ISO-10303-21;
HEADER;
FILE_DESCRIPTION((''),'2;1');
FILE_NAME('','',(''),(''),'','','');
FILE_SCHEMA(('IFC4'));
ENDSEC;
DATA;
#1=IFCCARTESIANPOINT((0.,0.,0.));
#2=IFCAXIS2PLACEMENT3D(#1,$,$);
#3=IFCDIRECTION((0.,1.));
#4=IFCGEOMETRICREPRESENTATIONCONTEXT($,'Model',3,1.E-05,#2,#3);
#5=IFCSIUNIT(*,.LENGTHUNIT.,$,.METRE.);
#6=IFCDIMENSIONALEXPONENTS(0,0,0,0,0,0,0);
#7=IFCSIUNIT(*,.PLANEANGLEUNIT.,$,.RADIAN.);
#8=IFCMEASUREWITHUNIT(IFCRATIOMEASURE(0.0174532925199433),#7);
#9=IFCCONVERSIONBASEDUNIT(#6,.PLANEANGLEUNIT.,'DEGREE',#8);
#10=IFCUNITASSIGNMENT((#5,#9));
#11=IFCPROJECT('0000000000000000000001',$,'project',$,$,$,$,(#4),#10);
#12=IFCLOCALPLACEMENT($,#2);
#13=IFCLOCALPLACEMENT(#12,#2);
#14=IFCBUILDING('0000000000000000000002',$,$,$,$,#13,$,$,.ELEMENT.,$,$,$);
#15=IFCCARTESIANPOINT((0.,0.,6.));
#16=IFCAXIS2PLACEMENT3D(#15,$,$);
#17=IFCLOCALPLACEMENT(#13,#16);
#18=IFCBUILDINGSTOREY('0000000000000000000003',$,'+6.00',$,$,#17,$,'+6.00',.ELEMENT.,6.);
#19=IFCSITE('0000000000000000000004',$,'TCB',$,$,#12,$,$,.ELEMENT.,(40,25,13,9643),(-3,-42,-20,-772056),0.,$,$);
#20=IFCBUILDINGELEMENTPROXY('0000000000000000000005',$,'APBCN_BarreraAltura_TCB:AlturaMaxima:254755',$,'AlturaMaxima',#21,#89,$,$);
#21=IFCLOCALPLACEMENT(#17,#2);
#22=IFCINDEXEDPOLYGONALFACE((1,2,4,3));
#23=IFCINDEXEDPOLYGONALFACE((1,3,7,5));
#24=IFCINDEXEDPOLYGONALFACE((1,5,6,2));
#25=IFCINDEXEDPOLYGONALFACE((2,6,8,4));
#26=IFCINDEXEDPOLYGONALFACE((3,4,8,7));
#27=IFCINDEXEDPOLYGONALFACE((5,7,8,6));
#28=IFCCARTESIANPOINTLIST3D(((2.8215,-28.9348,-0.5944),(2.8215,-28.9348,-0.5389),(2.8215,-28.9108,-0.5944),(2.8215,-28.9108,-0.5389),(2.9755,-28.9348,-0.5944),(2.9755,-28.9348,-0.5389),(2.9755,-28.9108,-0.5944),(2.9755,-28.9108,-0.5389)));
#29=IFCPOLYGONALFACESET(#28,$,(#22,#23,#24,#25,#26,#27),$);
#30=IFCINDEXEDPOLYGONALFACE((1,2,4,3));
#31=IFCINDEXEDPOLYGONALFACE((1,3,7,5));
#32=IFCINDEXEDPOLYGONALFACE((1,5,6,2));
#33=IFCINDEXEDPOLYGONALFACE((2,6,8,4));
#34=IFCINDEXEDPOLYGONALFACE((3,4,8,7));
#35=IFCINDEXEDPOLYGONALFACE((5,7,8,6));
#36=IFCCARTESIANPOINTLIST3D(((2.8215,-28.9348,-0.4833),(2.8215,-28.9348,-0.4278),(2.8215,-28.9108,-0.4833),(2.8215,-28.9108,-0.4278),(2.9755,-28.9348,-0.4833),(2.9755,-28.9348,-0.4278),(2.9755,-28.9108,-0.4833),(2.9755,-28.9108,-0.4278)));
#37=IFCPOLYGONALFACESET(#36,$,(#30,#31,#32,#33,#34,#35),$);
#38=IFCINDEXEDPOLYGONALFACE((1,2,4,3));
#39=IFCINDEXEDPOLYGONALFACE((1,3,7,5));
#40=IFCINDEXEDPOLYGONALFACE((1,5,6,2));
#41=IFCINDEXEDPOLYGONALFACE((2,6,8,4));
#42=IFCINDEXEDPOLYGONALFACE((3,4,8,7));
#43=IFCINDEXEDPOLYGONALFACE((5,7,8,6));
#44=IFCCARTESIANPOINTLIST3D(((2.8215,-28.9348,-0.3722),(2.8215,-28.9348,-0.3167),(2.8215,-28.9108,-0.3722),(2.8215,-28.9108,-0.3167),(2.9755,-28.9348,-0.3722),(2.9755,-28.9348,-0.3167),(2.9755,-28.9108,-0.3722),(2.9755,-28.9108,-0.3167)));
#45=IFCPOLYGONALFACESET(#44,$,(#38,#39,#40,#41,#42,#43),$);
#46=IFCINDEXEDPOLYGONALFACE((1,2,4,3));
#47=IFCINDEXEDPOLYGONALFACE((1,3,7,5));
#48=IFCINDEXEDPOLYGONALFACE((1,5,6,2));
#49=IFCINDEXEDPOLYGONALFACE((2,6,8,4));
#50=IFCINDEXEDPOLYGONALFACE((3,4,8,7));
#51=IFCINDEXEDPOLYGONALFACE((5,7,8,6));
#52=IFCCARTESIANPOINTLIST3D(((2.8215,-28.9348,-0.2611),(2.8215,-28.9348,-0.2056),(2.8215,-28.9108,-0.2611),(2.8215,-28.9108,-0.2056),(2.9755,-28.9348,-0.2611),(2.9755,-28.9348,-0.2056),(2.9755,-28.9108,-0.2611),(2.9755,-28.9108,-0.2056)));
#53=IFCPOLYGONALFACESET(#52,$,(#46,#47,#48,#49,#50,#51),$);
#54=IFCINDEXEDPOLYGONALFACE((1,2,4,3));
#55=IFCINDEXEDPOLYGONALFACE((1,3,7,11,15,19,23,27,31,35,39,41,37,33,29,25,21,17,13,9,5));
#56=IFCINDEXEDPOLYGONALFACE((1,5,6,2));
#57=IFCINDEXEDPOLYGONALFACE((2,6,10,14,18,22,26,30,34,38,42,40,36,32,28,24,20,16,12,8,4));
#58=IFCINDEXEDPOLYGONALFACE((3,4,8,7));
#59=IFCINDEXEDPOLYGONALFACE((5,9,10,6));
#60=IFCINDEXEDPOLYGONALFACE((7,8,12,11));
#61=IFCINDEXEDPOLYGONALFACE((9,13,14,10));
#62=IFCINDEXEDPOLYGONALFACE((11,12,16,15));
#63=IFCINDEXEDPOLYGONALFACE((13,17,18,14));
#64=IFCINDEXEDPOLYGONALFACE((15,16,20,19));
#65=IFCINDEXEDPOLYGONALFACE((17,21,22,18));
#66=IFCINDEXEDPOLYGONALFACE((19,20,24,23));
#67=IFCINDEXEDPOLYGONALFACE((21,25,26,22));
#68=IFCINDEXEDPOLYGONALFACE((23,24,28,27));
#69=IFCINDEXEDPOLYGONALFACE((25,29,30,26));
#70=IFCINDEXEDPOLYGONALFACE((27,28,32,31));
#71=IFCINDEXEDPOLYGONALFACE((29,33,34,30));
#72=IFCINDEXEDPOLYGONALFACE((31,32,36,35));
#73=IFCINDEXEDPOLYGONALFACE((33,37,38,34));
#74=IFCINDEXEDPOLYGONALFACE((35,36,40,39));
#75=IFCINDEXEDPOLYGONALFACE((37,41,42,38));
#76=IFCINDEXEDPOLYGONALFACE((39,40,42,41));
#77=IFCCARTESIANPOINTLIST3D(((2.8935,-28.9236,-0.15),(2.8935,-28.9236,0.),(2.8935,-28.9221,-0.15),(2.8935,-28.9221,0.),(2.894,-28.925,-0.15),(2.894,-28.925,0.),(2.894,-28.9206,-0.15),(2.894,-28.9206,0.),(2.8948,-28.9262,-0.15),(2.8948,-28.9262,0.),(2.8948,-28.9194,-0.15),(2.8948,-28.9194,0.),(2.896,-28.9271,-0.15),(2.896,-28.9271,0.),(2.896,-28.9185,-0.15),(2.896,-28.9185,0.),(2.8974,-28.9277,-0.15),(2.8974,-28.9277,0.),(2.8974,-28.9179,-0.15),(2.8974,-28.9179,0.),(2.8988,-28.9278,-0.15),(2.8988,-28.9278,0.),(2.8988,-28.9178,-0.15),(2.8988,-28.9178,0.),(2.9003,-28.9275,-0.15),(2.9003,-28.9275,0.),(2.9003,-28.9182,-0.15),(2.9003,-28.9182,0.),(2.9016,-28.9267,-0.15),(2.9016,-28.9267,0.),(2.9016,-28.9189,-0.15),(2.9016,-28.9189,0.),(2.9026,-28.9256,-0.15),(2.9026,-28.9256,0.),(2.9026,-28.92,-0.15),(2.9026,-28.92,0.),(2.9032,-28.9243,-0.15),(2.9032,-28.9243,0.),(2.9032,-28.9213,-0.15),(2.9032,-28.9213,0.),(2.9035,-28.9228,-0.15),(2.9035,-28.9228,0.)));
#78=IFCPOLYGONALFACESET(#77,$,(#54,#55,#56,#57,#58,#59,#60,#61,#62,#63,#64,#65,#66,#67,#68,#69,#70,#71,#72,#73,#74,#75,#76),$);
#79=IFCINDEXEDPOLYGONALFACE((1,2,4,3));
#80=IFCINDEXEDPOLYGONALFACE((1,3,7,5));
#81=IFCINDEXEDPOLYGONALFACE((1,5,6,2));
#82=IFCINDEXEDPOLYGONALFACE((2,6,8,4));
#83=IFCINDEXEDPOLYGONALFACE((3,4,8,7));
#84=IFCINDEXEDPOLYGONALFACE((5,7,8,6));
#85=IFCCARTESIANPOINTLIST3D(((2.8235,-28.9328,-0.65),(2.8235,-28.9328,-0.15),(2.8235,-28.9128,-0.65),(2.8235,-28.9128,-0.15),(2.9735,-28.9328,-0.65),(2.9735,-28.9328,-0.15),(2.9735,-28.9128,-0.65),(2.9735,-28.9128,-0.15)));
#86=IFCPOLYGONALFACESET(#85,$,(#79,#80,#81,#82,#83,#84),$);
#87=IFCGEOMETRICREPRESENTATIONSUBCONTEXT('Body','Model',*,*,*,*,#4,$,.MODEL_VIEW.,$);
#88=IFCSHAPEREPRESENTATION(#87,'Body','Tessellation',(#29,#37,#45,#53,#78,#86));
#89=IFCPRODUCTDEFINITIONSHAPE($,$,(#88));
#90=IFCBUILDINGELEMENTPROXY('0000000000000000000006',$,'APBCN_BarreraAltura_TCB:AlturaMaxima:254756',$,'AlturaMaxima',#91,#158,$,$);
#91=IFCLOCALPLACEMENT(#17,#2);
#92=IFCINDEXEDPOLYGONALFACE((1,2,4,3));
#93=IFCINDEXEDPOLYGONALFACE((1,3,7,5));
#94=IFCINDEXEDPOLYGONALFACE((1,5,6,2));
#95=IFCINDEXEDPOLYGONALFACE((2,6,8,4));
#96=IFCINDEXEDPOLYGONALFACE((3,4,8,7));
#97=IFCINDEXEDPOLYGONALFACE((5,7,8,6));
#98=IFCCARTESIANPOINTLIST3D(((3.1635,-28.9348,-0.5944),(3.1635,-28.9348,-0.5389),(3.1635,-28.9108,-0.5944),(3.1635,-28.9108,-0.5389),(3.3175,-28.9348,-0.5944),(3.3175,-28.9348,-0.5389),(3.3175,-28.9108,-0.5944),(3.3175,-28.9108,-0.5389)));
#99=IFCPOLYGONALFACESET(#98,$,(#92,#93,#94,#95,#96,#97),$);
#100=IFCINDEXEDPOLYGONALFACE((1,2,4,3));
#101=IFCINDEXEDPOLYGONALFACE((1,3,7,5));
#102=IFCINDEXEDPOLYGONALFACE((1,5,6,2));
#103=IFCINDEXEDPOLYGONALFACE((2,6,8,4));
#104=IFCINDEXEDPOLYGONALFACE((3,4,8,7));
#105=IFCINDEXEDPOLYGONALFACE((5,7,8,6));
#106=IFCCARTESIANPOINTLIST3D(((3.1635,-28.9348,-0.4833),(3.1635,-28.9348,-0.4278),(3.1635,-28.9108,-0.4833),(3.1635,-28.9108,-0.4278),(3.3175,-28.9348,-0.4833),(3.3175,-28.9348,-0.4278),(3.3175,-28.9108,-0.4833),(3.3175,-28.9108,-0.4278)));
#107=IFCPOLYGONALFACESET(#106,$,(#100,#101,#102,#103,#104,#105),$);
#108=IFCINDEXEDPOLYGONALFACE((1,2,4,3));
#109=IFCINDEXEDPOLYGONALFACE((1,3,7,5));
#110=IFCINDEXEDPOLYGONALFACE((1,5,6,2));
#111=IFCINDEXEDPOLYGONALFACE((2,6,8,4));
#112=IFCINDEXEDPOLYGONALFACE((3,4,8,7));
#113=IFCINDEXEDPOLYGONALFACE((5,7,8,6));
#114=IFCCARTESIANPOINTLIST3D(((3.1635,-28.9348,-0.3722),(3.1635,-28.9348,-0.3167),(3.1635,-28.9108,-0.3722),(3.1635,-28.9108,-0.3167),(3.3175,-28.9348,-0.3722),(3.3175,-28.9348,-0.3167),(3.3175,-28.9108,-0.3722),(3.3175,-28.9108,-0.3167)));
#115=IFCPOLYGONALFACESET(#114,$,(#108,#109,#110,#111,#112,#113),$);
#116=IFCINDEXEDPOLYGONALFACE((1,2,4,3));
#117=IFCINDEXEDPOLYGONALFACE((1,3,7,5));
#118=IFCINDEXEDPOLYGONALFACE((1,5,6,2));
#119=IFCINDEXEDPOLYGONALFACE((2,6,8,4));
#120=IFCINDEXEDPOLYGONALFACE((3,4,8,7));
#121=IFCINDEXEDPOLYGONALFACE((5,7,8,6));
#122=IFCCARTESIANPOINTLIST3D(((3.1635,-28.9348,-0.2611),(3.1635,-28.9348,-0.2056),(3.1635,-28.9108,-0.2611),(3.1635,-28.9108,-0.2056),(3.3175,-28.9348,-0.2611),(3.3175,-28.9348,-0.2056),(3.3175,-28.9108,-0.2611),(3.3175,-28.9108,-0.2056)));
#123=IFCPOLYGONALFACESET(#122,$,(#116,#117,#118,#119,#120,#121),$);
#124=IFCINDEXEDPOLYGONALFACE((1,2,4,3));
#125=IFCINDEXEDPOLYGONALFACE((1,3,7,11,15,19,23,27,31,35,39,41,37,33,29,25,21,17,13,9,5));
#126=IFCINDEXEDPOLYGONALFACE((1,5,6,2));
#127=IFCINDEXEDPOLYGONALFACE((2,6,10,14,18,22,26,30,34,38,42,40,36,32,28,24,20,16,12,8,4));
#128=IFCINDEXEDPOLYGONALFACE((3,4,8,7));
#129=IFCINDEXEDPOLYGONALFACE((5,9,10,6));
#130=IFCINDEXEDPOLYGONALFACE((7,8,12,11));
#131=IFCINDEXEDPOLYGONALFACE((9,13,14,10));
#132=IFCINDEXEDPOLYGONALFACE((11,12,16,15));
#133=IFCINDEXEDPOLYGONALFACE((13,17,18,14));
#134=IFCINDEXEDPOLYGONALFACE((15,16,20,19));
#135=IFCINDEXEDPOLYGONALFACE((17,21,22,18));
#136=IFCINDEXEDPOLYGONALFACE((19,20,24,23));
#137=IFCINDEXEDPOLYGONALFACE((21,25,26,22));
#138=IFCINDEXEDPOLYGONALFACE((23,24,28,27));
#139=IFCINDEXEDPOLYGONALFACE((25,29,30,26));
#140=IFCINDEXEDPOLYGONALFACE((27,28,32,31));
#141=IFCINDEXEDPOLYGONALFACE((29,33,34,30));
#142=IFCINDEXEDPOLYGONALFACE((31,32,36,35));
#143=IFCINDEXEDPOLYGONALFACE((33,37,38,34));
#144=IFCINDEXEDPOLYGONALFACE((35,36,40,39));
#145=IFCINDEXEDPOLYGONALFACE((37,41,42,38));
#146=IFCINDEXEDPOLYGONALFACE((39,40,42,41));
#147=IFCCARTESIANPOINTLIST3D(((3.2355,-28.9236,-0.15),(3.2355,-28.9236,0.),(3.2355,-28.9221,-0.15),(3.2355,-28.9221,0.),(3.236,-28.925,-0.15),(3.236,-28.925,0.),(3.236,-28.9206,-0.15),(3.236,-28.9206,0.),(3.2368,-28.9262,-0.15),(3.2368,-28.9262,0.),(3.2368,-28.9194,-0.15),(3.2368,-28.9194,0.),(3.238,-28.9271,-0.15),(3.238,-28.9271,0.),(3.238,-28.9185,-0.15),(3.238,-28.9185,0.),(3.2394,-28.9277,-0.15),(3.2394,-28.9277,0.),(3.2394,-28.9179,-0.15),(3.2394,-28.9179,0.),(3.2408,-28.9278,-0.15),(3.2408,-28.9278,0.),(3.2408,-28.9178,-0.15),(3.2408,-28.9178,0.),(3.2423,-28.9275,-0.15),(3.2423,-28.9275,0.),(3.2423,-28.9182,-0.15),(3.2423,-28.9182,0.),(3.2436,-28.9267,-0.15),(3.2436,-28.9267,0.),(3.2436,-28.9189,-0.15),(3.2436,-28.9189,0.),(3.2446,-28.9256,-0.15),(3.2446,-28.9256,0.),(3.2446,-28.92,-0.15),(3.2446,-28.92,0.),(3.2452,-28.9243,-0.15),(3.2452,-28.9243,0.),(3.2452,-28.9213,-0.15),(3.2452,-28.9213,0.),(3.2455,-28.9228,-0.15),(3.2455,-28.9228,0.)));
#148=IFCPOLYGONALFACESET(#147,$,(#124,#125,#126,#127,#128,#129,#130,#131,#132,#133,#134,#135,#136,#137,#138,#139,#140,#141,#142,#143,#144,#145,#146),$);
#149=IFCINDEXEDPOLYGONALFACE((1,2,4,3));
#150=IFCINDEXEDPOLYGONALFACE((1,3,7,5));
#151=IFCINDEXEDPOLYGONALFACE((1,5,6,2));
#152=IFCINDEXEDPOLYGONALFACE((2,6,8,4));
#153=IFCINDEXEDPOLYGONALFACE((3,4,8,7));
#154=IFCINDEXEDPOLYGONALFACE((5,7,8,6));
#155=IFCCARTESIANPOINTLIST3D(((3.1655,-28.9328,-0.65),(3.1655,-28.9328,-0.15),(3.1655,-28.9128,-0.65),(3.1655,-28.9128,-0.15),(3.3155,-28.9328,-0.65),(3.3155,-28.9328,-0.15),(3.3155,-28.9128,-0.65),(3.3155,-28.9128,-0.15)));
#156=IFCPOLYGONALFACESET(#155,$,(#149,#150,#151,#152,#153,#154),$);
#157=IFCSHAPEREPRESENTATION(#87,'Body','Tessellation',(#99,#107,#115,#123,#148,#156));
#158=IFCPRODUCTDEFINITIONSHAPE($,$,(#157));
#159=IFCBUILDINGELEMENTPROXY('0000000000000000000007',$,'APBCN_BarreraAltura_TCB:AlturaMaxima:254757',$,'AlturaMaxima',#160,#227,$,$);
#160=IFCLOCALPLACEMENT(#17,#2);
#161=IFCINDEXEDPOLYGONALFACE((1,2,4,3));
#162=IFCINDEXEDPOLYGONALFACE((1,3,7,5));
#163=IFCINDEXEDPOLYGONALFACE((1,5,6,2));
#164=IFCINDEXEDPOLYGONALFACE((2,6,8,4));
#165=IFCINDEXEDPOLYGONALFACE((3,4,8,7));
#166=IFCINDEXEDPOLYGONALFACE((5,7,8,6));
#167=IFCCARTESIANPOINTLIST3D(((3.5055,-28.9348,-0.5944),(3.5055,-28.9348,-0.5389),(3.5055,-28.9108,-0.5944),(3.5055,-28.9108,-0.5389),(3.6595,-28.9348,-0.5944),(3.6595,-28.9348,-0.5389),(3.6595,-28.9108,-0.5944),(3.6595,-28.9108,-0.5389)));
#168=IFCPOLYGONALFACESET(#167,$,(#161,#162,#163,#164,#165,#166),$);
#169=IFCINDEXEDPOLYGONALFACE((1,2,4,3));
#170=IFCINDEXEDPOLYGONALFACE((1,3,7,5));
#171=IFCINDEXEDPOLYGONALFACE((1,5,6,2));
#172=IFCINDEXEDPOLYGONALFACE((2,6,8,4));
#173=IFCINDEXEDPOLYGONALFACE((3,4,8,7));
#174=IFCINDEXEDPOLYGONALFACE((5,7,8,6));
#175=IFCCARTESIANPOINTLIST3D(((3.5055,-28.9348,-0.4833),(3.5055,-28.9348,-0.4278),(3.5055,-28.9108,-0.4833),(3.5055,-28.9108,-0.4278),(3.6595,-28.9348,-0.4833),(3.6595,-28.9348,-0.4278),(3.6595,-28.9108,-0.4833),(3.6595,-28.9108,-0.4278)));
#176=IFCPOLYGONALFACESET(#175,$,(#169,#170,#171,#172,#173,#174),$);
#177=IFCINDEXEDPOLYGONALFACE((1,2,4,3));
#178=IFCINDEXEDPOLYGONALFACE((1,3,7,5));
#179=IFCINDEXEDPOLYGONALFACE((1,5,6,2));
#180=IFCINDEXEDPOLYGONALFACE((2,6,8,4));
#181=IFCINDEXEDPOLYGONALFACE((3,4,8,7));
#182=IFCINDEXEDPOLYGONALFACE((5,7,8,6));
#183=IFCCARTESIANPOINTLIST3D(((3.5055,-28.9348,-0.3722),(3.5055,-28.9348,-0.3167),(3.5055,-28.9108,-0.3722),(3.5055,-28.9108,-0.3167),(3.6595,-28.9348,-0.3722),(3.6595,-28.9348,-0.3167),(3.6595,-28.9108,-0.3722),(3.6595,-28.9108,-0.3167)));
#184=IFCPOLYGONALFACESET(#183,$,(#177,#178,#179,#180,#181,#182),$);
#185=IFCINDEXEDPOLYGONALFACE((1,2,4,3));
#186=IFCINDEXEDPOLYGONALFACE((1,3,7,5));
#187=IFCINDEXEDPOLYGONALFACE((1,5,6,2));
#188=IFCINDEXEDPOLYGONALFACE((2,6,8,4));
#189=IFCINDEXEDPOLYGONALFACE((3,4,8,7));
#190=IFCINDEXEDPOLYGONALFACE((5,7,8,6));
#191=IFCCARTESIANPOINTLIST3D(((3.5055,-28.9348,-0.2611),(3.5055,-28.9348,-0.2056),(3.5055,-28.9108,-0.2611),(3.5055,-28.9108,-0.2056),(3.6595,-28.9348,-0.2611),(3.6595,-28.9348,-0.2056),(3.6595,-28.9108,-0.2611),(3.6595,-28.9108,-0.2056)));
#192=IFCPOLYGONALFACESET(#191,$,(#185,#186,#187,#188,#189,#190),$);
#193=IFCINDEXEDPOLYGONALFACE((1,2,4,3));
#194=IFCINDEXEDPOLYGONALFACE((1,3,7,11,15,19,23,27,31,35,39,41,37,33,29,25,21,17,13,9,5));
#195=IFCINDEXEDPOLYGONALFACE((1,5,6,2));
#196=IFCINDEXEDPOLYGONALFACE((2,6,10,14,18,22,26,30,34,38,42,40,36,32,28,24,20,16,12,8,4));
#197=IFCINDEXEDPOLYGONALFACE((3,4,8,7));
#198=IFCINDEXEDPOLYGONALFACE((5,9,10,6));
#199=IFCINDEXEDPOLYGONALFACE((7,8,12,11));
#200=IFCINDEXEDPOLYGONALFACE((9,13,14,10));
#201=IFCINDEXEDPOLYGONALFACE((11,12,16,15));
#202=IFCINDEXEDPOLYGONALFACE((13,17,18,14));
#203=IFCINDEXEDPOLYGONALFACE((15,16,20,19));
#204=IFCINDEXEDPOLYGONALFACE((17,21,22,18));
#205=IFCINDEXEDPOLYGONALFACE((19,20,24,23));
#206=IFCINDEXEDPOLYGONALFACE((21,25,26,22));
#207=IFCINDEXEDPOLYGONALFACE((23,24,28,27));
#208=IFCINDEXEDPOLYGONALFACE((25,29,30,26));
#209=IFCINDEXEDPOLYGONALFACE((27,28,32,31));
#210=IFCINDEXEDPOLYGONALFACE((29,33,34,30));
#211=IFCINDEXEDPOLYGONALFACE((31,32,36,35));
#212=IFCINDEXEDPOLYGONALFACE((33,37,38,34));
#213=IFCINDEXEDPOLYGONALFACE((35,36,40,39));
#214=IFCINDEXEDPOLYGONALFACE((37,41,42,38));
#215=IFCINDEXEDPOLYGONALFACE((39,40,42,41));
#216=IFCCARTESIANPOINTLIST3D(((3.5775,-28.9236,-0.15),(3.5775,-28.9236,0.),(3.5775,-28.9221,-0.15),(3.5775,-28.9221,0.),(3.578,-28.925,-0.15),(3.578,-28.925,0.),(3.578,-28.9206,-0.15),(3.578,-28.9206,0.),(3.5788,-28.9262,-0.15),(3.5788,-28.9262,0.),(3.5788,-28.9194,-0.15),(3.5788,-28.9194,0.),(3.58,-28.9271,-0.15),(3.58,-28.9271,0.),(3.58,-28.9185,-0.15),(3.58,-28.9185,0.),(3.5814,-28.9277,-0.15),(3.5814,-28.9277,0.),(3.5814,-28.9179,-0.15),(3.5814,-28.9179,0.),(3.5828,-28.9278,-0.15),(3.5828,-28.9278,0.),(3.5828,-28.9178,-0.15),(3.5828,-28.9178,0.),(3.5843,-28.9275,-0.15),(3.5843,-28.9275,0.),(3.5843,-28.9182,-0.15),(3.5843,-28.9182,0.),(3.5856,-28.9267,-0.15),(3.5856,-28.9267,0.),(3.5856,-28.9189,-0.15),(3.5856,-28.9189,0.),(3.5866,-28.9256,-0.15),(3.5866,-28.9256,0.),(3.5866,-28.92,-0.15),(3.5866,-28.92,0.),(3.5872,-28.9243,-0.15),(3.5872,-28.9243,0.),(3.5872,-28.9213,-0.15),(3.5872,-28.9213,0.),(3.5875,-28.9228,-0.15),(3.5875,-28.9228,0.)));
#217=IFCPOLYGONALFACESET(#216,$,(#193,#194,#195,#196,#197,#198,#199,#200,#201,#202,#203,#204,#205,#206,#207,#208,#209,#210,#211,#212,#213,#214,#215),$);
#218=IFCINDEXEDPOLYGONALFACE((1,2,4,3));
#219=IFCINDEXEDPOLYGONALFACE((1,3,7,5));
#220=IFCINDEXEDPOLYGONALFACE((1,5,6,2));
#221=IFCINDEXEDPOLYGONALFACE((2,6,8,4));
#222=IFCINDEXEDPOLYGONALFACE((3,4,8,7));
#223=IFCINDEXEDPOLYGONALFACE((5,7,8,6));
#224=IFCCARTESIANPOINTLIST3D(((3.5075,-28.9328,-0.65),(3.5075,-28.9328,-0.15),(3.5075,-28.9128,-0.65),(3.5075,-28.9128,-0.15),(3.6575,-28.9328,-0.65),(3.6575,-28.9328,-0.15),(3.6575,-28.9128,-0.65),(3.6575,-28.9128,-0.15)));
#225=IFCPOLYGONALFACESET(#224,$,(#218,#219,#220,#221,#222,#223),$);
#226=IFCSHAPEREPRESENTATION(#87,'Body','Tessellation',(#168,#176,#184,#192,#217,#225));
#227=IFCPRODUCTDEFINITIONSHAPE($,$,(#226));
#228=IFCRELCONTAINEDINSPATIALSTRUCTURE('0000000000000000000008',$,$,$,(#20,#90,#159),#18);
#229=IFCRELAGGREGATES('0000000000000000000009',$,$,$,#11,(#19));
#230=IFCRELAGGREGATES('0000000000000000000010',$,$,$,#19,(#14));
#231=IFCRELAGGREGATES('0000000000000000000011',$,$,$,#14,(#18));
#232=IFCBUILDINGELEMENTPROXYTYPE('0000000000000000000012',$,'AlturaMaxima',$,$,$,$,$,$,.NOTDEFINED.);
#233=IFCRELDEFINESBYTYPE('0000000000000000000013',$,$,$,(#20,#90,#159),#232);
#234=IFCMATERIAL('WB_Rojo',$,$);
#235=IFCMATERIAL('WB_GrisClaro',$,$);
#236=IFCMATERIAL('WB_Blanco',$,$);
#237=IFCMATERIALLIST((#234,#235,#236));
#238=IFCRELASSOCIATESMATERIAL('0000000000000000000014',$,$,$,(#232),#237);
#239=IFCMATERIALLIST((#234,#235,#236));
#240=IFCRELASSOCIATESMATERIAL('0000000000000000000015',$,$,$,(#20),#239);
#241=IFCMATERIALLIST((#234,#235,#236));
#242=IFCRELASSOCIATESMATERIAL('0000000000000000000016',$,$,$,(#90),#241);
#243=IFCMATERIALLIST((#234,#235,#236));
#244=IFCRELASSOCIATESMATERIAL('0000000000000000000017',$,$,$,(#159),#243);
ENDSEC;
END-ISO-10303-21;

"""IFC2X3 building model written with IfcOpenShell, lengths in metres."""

from ifc_helpers import new_model, entity, si_unit, converted_unit, direction, frame, frame_2d, origin, origin_2d_with_axis, place, context, subcontext, project, spatial, rectangle, circle, extrude, source, transform, mapped, material, material_list, type_object, type_shapes, element, save


model = new_model("IFC2X3")

# Units and contexts
model_context = context("Model", 3, precision=1e-05, world=origin(), true_north=direction((0.0, 1.0)))
body_context = subcontext(model_context, "Body", "Model", "MODEL_VIEW")
ifc_project = project(units=[si_unit("LENGTHUNIT", "METRE"), converted_unit("PLANEANGLEUNIT", "DEGREE", entity("IfcRatioMeasure", 0.0174532925199433), si_unit("PLANEANGLEUNIT", "RADIAN"), dimensions=[0, 0, 0, 0, 0, 0, 0])], contexts=[model_context])

# Site, building, storey
site_placement = place(None, origin())
site = spatial("IfcSite", under=ifc_project, at=site_placement, Name="TCB", CompositionType="ELEMENT", RefLatitude=(40, 25, 13, 9643), RefLongitude=(-3, -42, -20, -772056), RefElevation=0.0)
building_placement = place(site_placement, origin())
building = spatial("IfcBuilding", under=site, at=building_placement, CompositionType="ELEMENT")
storey_placement = place(building_placement, frame((0.0, 0.0, 6.0)))
storey = spatial("IfcBuildingStorey", under=building, at=storey_placement, Name="+6.00", LongName="+6.00", CompositionType="ELEMENT", Elevation=6.0)

# Building element proxies
ifc_material_1 = material(Name="WB_Rojo")
ifc_material_2 = material(Name="WB_GrisClaro")
ifc_material_3 = material(Name="WB_Blanco")
ifc_material_list_1 = material_list([ifc_material_1, ifc_material_2, ifc_material_3])
building_element_proxy_type = type_object("IfcBuildingElementProxyType", Name="AlturaMaxima", PredefinedType="NOTDEFINED", material=ifc_material_list_1)
shared_shape = source(origin(), body_context, "Body", "SweptSolid", [
    extrude(rectangle(XDim=0.154, YDim=0.024, at=frame_2d((0.0, 0.0), x_axis=(1.0, 0.0))), frame((0.0, 0.0, -0.5944), z_axis=(0.0, 0.0, 1.0), x_axis=(-1.0, 0.0, 0.0)), (0.0, 0.0, 1.0), 0.0556),
    extrude(rectangle(XDim=0.154, YDim=0.024, at=frame_2d((0.0, 0.0), x_axis=(1.0, 0.0))), frame((0.0, 0.0, -0.4833), z_axis=(0.0, 0.0, 1.0), x_axis=(-1.0, 0.0, 0.0)), (0.0, 0.0, 1.0), 0.0556),
    extrude(rectangle(XDim=0.154, YDim=0.024, at=frame_2d((0.0, 0.0), x_axis=(1.0, 0.0))), frame((0.0, 0.0, -0.3722), z_axis=(0.0, 0.0, 1.0), x_axis=(-1.0, 0.0, 0.0)), (0.0, 0.0, 1.0), 0.0556),
    extrude(rectangle(XDim=0.154, YDim=0.024, at=frame_2d((0.0, 0.0), x_axis=(1.0, 0.0))), frame((0.0, 0.0, -0.2611), z_axis=(0.0, 0.0, 1.0), x_axis=(-1.0, 0.0, 0.0)), (0.0, 0.0, 1.0), 0.0556),
    extrude(circle(Radius=0.005, at=frame_2d((0.0, 0.0), x_axis=(1.0, 0.0))), frame((0.0, 0.0, -0.15)), (0.0, 0.0, 1.0), 0.15),
    extrude(rectangle(XDim=0.02, YDim=0.15, at=origin_2d_with_axis()), frame((0.0, 0.0, -0.65), z_axis=(0.0, 0.0, 1.0), x_axis=(0.0, 1.0, 0.0)), (0.0, 0.0, 1.0), 0.5),
])
type_shapes(building_element_proxy_type, [shared_shape])
ifc_material_list_2 = material_list([ifc_material_1, ifc_material_2, ifc_material_3])
proxy_1_placement = place(storey_placement, frame((2.8985, -28.9228, 0.0)))
element("IfcBuildingElementProxy", 1, at=proxy_1_placement, inside=storey, type_object=building_element_proxy_type, material=ifc_material_list_2, Name="APBCN_BarreraAltura_TCB:AlturaMaxima:254755", ObjectType="AlturaMaxima", context=body_context, shape_type="MappedRepresentation", body=[
    mapped(shared_shape, transform((0.0, 0.0, 0.0), scale=1.0)),
])
ifc_material_list_3 = material_list([ifc_material_1, ifc_material_2, ifc_material_3])
proxy_2_placement = place(storey_placement, frame((3.2405, -28.9228, 0.0)))
element("IfcBuildingElementProxy", 2, at=proxy_2_placement, inside=storey, type_object=building_element_proxy_type, material=ifc_material_list_3, Name="APBCN_BarreraAltura_TCB:AlturaMaxima:254756", ObjectType="AlturaMaxima", context=body_context, shape_type="MappedRepresentation", body=[
    mapped(shared_shape, transform((0.0, 0.0, 0.0), scale=1.0)),
])
ifc_material_list_4 = material_list([ifc_material_1, ifc_material_2, ifc_material_3])
proxy_3_placement = place(storey_placement, frame((3.5825, -28.9228, 0.0)))
element("IfcBuildingElementProxy", 3, at=proxy_3_placement, inside=storey, type_object=building_element_proxy_type, material=ifc_material_list_4, Name="APBCN_BarreraAltura_TCB:AlturaMaxima:254757", ObjectType="AlturaMaxima", context=body_context, shape_type="MappedRepresentation", body=[
    mapped(shared_shape, transform((0.0, 0.0, 0.0), scale=1.0)),
])

save(model, "model.ifc")
